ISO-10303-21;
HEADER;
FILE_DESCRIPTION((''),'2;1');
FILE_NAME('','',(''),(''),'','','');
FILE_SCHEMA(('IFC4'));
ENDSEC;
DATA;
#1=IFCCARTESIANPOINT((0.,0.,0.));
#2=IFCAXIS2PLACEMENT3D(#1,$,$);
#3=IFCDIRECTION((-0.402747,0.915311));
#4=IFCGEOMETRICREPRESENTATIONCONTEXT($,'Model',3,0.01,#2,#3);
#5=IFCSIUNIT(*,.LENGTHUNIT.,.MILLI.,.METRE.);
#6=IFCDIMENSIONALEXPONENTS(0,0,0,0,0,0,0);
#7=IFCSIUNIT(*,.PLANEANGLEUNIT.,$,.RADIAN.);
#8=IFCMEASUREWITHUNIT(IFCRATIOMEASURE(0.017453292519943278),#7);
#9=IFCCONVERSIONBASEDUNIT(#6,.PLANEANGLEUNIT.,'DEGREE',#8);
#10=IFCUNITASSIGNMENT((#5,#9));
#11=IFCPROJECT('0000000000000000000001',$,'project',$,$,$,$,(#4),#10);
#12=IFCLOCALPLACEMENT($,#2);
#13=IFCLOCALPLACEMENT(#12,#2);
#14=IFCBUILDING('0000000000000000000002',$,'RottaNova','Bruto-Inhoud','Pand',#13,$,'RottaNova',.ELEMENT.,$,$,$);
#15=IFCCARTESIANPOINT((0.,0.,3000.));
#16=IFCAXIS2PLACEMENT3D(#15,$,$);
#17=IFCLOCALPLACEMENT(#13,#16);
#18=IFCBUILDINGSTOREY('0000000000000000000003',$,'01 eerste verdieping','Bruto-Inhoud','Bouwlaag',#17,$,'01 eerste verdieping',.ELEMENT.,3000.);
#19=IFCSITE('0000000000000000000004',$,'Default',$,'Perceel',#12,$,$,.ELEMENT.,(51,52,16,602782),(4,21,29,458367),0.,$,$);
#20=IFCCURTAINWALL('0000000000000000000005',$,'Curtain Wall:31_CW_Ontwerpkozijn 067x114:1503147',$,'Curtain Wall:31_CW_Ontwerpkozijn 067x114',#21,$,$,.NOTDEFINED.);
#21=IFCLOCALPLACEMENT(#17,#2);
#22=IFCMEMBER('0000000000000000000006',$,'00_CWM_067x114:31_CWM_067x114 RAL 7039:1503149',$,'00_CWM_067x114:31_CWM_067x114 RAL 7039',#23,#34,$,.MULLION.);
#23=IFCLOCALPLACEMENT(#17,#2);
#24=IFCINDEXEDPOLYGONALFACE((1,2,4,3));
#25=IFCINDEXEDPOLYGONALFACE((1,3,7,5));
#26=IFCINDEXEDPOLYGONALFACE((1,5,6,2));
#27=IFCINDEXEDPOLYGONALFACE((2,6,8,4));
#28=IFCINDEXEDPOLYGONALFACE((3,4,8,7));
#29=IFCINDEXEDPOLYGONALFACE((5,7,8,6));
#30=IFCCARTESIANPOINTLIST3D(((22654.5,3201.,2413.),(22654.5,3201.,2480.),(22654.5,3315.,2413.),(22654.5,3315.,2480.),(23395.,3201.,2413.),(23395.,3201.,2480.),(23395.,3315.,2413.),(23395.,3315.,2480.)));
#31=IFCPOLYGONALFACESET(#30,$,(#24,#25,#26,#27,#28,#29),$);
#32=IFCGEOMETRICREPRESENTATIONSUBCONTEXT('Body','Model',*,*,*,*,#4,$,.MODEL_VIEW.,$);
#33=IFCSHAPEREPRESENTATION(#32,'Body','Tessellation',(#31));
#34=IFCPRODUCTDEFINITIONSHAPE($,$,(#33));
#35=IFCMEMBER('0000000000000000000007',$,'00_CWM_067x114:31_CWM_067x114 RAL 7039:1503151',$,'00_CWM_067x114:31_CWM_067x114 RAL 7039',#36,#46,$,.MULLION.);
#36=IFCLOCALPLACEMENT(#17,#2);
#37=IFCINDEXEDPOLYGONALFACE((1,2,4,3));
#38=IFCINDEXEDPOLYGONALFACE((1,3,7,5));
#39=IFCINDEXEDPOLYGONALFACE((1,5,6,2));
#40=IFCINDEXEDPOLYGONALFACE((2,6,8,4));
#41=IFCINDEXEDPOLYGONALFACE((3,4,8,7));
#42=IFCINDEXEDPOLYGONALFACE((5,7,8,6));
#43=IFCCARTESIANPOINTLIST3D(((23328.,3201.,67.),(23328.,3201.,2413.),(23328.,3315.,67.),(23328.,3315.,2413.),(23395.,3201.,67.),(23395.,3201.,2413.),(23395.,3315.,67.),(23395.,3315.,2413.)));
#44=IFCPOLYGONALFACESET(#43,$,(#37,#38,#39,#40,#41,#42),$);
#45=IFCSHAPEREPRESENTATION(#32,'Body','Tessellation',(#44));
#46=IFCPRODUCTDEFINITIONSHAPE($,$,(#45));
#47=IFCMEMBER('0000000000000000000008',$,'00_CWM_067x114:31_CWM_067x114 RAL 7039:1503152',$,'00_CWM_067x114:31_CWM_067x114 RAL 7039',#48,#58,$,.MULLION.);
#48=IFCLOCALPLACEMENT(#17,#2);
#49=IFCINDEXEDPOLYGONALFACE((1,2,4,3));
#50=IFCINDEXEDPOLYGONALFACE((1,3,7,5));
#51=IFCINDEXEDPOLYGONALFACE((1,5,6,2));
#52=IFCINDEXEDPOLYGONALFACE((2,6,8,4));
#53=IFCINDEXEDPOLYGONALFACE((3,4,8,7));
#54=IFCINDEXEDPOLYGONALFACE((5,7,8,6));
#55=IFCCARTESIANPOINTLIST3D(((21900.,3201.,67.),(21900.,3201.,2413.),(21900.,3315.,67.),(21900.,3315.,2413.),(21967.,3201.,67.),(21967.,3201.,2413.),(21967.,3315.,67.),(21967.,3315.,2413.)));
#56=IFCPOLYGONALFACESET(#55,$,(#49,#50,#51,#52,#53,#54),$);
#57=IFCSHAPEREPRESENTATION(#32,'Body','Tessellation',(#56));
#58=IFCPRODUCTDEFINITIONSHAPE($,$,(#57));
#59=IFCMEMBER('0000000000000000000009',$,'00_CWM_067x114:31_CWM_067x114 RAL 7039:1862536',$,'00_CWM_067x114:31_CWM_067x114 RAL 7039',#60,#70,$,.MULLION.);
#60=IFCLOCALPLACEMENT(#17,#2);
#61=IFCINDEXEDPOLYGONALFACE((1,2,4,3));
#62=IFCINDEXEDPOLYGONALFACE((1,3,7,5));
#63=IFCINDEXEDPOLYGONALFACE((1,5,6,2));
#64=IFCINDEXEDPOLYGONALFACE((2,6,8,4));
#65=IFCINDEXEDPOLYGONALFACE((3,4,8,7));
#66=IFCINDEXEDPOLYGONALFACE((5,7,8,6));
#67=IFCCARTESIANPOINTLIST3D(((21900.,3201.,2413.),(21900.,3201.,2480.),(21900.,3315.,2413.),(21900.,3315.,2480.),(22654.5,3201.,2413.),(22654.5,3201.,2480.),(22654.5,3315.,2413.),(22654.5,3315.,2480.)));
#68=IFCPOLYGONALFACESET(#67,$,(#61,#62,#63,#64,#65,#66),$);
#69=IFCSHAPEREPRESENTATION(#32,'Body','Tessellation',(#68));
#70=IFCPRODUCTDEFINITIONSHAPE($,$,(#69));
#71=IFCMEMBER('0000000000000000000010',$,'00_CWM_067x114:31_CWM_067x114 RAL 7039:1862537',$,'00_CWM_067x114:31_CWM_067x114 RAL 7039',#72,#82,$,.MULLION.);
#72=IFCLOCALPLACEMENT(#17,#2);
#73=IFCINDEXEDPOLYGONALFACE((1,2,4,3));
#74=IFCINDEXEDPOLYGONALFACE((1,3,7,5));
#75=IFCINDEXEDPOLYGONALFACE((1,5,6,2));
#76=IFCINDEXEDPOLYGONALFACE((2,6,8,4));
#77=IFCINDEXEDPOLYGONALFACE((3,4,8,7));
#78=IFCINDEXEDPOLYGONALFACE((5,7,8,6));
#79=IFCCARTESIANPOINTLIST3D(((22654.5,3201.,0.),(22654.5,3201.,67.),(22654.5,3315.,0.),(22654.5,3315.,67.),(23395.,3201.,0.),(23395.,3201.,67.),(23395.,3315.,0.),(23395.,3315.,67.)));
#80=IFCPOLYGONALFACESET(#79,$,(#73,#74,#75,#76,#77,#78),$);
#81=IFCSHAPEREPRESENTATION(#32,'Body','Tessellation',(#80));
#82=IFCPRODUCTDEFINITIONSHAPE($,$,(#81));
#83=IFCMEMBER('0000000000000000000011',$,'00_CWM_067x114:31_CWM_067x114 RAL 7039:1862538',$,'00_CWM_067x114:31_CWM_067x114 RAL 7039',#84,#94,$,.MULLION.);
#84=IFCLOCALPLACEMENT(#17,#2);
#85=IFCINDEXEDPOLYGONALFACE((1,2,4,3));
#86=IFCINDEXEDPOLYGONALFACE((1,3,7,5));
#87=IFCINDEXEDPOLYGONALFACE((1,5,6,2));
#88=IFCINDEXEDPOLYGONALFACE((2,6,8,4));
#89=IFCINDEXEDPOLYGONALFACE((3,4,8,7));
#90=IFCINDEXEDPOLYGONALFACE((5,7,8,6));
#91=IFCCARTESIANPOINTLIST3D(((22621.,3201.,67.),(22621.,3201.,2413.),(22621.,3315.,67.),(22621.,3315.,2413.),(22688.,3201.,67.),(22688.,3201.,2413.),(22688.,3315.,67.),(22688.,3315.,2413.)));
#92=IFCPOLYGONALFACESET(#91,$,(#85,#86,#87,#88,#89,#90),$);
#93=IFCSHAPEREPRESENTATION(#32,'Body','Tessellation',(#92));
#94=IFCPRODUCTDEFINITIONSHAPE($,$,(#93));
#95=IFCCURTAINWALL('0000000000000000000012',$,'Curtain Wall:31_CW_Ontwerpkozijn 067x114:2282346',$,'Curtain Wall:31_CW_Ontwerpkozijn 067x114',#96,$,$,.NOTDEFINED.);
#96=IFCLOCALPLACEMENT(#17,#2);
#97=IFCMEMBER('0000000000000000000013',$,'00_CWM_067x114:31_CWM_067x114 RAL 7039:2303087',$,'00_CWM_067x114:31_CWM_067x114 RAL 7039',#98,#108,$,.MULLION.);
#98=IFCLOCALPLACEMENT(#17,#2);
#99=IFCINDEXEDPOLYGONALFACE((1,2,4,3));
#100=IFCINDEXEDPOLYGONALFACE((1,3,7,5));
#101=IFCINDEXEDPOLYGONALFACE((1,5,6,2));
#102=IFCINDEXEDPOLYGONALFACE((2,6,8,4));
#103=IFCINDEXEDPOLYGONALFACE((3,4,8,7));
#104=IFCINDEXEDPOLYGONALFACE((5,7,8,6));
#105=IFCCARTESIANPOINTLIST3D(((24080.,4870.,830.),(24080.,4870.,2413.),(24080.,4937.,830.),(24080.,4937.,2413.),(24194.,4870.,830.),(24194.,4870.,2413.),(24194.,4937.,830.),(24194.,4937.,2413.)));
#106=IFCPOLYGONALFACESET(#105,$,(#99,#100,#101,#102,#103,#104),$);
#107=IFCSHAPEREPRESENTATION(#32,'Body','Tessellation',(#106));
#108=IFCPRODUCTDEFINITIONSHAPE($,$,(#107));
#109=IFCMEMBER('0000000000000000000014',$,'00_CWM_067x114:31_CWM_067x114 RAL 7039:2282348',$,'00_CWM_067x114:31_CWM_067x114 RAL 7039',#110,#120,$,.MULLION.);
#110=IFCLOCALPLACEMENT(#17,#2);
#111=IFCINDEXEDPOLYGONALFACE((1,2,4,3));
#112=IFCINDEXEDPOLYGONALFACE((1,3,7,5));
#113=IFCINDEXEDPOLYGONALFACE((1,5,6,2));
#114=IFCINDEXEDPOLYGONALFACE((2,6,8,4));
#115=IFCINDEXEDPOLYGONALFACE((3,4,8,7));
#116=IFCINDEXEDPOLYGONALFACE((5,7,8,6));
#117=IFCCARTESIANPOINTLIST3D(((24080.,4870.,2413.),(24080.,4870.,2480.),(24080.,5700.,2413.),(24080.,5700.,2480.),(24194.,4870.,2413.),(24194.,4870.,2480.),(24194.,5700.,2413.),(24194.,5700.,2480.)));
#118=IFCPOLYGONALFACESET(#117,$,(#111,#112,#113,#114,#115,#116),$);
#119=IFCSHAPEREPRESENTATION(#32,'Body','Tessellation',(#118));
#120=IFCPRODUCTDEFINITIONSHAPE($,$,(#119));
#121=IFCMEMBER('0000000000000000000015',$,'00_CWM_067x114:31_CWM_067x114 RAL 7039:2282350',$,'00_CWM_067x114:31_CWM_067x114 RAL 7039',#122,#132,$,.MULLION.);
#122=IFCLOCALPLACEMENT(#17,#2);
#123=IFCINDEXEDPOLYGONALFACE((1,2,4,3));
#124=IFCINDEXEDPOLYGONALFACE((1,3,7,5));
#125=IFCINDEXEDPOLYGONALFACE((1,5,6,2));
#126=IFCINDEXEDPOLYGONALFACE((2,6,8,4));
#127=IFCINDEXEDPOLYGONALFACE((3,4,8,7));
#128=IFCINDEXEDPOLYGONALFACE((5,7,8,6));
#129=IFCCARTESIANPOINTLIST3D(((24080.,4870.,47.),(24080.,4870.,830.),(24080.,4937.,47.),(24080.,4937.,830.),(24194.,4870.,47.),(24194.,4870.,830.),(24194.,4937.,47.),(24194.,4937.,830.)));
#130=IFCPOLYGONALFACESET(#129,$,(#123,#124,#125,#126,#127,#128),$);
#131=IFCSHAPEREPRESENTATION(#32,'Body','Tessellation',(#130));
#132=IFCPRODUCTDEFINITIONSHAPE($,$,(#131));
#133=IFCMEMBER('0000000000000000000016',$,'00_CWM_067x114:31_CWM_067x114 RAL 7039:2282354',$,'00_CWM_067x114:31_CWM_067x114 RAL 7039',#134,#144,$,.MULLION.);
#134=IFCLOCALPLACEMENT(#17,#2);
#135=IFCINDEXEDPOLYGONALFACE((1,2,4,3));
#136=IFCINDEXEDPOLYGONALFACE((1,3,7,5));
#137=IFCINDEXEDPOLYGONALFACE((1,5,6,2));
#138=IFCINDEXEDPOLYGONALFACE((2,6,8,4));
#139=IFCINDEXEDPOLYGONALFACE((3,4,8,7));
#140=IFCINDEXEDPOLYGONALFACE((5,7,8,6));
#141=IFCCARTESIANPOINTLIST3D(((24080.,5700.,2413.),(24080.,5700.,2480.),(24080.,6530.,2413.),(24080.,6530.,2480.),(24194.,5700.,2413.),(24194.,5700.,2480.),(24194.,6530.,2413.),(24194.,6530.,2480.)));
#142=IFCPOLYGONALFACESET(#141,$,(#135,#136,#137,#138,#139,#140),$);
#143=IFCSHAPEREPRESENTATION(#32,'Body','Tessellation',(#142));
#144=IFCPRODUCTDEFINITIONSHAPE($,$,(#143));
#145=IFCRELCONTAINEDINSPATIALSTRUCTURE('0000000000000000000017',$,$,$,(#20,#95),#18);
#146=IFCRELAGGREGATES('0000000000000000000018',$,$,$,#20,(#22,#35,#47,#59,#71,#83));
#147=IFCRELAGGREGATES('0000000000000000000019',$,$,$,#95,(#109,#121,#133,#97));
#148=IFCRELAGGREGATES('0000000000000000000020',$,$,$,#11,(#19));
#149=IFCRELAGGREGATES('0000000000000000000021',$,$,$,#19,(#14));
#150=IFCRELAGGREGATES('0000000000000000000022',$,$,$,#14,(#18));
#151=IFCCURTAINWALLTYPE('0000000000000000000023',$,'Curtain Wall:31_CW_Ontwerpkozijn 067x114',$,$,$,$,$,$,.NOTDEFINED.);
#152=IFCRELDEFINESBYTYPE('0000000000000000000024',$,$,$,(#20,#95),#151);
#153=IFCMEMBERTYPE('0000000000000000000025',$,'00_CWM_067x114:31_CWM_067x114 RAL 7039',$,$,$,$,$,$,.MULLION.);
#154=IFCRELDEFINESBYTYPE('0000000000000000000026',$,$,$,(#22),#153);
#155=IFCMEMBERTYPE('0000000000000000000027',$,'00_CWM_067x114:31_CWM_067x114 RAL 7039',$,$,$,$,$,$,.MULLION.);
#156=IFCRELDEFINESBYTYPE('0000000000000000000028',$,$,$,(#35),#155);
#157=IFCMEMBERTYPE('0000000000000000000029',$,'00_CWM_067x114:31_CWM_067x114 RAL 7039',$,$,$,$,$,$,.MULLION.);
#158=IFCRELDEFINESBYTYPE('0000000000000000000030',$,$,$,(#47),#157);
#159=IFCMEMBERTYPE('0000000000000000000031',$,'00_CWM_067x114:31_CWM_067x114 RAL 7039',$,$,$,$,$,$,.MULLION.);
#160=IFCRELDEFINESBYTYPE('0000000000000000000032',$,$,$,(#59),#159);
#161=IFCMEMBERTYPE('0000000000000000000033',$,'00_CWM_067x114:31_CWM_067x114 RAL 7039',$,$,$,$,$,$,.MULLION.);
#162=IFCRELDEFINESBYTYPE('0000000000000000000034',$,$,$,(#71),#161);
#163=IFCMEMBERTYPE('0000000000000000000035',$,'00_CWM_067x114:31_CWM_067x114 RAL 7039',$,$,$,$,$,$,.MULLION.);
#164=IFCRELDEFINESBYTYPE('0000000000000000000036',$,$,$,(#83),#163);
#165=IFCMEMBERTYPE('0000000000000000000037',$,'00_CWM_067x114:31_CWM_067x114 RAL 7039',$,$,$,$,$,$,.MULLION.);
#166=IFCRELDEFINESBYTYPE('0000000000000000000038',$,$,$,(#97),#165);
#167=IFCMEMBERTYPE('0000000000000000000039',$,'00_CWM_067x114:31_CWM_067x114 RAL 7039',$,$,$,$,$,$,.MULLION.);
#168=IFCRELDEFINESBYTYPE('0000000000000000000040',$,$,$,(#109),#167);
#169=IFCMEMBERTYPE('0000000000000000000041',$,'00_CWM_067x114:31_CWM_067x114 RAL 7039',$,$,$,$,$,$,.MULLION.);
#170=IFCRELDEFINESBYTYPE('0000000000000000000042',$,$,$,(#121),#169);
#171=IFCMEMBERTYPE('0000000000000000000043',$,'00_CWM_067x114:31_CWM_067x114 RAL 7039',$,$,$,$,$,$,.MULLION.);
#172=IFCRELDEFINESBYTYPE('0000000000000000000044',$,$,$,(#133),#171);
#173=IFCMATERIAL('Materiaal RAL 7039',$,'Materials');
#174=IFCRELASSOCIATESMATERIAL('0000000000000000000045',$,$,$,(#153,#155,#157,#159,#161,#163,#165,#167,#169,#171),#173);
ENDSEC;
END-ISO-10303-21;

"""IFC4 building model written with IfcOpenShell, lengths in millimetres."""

from ifc_helpers import new_model, entity, si_unit, converted_unit, direction, frame, frame_2d, origin, origin_2d_with_axis, place, context, subcontext, project, spatial, rectangle, extrude, source, transform, mapped, material, material_profile, profile_set, type_object, type_shapes, element, aggregate, save


model = new_model("IFC4")

# Units and contexts
model_context = context("Model", 3, precision=0.01, world=origin(), true_north=direction((-0.402747, 0.915311)))
body_context = subcontext(model_context, "Body", "Model", "MODEL_VIEW")
ifc_project = project(units=[si_unit("LENGTHUNIT", "METRE", prefix="MILLI"), converted_unit("PLANEANGLEUNIT", "DEGREE", entity("IfcRatioMeasure", 0.017453292519943278), si_unit("PLANEANGLEUNIT", "RADIAN"), dimensions=[0, 0, 0, 0, 0, 0, 0])], contexts=[model_context])

# Site, building, storey
site_placement = place(None, origin())
site = spatial("IfcSite", under=ifc_project, at=site_placement, Name="Default", ObjectType="Perceel", CompositionType="ELEMENT", RefLatitude=(51, 52, 16, 602782), RefLongitude=(4, 21, 29, 458367), RefElevation=0.0)
building_placement = place(site_placement, origin())
building = spatial("IfcBuilding", under=site, at=building_placement, Name="RottaNova", Description="Bruto-Inhoud", ObjectType="Pand", LongName="RottaNova", CompositionType="ELEMENT")
storey_placement = place(building_placement, frame((0.0, 0.0, 3000.0)))
storey = spatial("IfcBuildingStorey", under=building, at=storey_placement, Name="01 eerste verdieping", Description="Bruto-Inhoud", ObjectType="Bouwlaag", LongName="01 eerste verdieping", CompositionType="ELEMENT", Elevation=3000.0)

# Curtain walls, members
curtain_wall_type = type_object("IfcCurtainWallType", Name="Curtain Wall:31_CW_Ontwerpkozijn 067x114", PredefinedType="NOTDEFINED")
curtain_wall_1_placement = place(storey_placement, frame((0.0, 0.0, -3000.0)))
curtain_wall_1 = element("IfcCurtainWall", 1, at=curtain_wall_1_placement, inside=storey, type_object=curtain_wall_type, Name="Curtain Wall:31_CW_Ontwerpkozijn 067x114:1503147", ObjectType="Curtain Wall:31_CW_Ontwerpkozijn 067x114", PredefinedType="NOTDEFINED")
ifc_material_1 = material(Name="Materiaal RAL 7039", Category="Materials")
ifc_material_profile = material_profile(ifc_material_1, rectangle(XDim=114.0, YDim=67.0, at=origin_2d_with_axis()), Name="31_CWM_067x114 RAL 7039")
ifc_profile_set = profile_set([ifc_material_profile], Name="31_CWM_067x114 RAL 7039")
member_type_1 = type_object("IfcMemberType", Name="00_CWM_067x114:31_CWM_067x114 RAL 7039", PredefinedType="MULLION", material=ifc_profile_set)
shared_shape_1 = source(origin(), body_context, "Body", "SweptSolid", [
    extrude(rectangle(XDim=114.0, YDim=67.0, at=origin_2d_with_axis()), frame((-33.5, 57.0, -740.5), z_axis=(0.0, 0.0, 1.0), x_axis=(0.0, -1.0, 0.0)), (0.0, 0.0, 1.0), 740.5),
])
type_shapes(member_type_1, [shared_shape_1])
member_1_placement = place(curtain_wall_1_placement, frame((23395.0, 3315.0, 5480.0), z_axis=(1.0, 0.0, 0.0), x_axis=(0.0, 0.0, 1.0)))
member_1 = element("IfcMember", 2, at=member_1_placement, type_object=member_type_1, Name="00_CWM_067x114:31_CWM_067x114 RAL 7039:1503149", ObjectType="00_CWM_067x114:31_CWM_067x114 RAL 7039", PredefinedType="MULLION", context=body_context, shape_type="MappedRepresentation", body=[
    mapped(shared_shape_1, transform((0.0, 0.0, 0.0), scale=1.0)),
])
member_type_2 = type_object("IfcMemberType", Name="00_CWM_067x114:31_CWM_067x114 RAL 7039", PredefinedType="MULLION", material=ifc_profile_set)
shared_shape_2 = source(origin(), body_context, "Body", "SweptSolid", [
    extrude(rectangle(XDim=114.0, YDim=67.0, at=origin_2d_with_axis()), frame((-33.5, 57.0, -2346.0), z_axis=(0.0, 0.0, 1.0), x_axis=(0.0, -1.0, 0.0)), (0.0, 0.0, 1.0), 2346.0),
])
type_shapes(member_type_2, [shared_shape_2])
member_2_placement = place(curtain_wall_1_placement, frame((23395.0, 3315.0, 3067.0), z_axis=(0.0, 0.0, -1.0), x_axis=(1.0, 0.0, 0.0)))
member_2 = element("IfcMember", 3, at=member_2_placement, type_object=member_type_2, Name="00_CWM_067x114:31_CWM_067x114 RAL 7039:1503151", ObjectType="00_CWM_067x114:31_CWM_067x114 RAL 7039", PredefinedType="MULLION", context=body_context, shape_type="MappedRepresentation", body=[
    mapped(shared_shape_2, transform((0.0, 0.0, 0.0), scale=1.0)),
])
member_type_3 = type_object("IfcMemberType", Name="00_CWM_067x114:31_CWM_067x114 RAL 7039", PredefinedType="MULLION", material=ifc_profile_set)
shared_shape_3 = source(origin(), body_context, "Body", "SweptSolid", [
    extrude(rectangle(XDim=114.0, YDim=67.0, at=origin_2d_with_axis()), frame((-33.5, 57.0, -2346.0), z_axis=(0.0, 0.0, 1.0), x_axis=(0.0, -1.0, 0.0)), (0.0, 0.0, 1.0), 2346.0),
])
type_shapes(member_type_3, [shared_shape_3])
member_3_placement = place(curtain_wall_1_placement, frame((21900.0, 3315.0, 5413.0), z_axis=(0.0, 0.0, 1.0), x_axis=(-1.0, 0.0, 0.0)))
member_3 = element("IfcMember", 4, at=member_3_placement, type_object=member_type_3, Name="00_CWM_067x114:31_CWM_067x114 RAL 7039:1503152", ObjectType="00_CWM_067x114:31_CWM_067x114 RAL 7039", PredefinedType="MULLION", context=body_context, shape_type="MappedRepresentation", body=[
    mapped(shared_shape_3, transform((0.0, 0.0, 0.0), scale=1.0)),
])
member_type_4 = type_object("IfcMemberType", Name="00_CWM_067x114:31_CWM_067x114 RAL 7039", PredefinedType="MULLION", material=ifc_profile_set)
shared_shape_4 = source(origin(), body_context, "Body", "SweptSolid", [
    extrude(rectangle(XDim=114.0, YDim=67.0, at=origin_2d_with_axis()), frame((-33.5, 57.0, -754.5), z_axis=(0.0, 0.0, 1.0), x_axis=(0.0, -1.0, 0.0)), (0.0, 0.0, 1.0), 754.5),
])
type_shapes(member_type_4, [shared_shape_4])
member_4_placement = place(curtain_wall_1_placement, frame((22654.5, 3315.0, 5480.0), z_axis=(1.0, 0.0, 0.0), x_axis=(0.0, 0.0, 1.0)))
member_4 = element("IfcMember", 5, at=member_4_placement, type_object=member_type_4, Name="00_CWM_067x114:31_CWM_067x114 RAL 7039:1862536", ObjectType="00_CWM_067x114:31_CWM_067x114 RAL 7039", PredefinedType="MULLION", context=body_context, shape_type="MappedRepresentation", body=[
    mapped(shared_shape_4, transform((0.0, 0.0, 0.0), scale=1.0)),
])
member_type_5 = type_object("IfcMemberType", Name="00_CWM_067x114:31_CWM_067x114 RAL 7039", PredefinedType="MULLION", material=ifc_profile_set)
shared_shape_5 = source(origin(), body_context, "Body", "SweptSolid", [
    extrude(rectangle(XDim=114.0, YDim=67.0, at=origin_2d_with_axis()), frame((-33.5, 57.0, -740.5), z_axis=(0.0, 0.0, 1.0), x_axis=(0.0, -1.0, 0.0)), (0.0, 0.0, 1.0), 740.5),
])
type_shapes(member_type_5, [shared_shape_5])
member_5_placement = place(curtain_wall_1_placement, frame((22654.5, 3315.0, 3000.0), z_axis=(-1.0, 0.0, 0.0), x_axis=(0.0, 0.0, -1.0)))
member_5 = element("IfcMember", 6, at=member_5_placement, type_object=member_type_5, Name="00_CWM_067x114:31_CWM_067x114 RAL 7039:1862537", ObjectType="00_CWM_067x114:31_CWM_067x114 RAL 7039", PredefinedType="MULLION", context=body_context, shape_type="MappedRepresentation", body=[
    mapped(shared_shape_5, transform((0.0, 0.0, 0.0), scale=1.0)),
])
member_type_6 = type_object("IfcMemberType", Name="00_CWM_067x114:31_CWM_067x114 RAL 7039", PredefinedType="MULLION", material=ifc_profile_set)
shared_shape_6 = source(origin(), body_context, "Body", "SweptSolid", [
    extrude(rectangle(XDim=114.0, YDim=67.0, at=origin_2d_with_axis()), frame((0.0, 57.0, -2346.0), z_axis=(0.0, 0.0, 1.0), x_axis=(0.0, -1.0, 0.0)), (0.0, 0.0, 1.0), 2346.0),
])
type_shapes(member_type_6, [shared_shape_6])
member_6_placement = place(curtain_wall_1_placement, frame((22654.5, 3315.0, 3067.0), z_axis=(0.0, 0.0, -1.0), x_axis=(1.0, 0.0, 0.0)))
member_6 = element("IfcMember", 7, at=member_6_placement, type_object=member_type_6, Name="00_CWM_067x114:31_CWM_067x114 RAL 7039:1862538", ObjectType="00_CWM_067x114:31_CWM_067x114 RAL 7039", PredefinedType="MULLION", context=body_context, shape_type="MappedRepresentation", body=[
    mapped(shared_shape_6, transform((0.0, 0.0, 0.0), scale=1.0)),
])
aggregate(curtain_wall_1, [member_1, member_2, member_3, member_4, member_5, member_6])
curtain_wall_2_placement = place(storey_placement, frame((0.0, 0.0, -3000.0)))
curtain_wall_2 = element("IfcCurtainWall", 8, at=curtain_wall_2_placement, inside=storey, type_object=curtain_wall_type, Name="Curtain Wall:31_CW_Ontwerpkozijn 067x114:2282346", ObjectType="Curtain Wall:31_CW_Ontwerpkozijn 067x114", PredefinedType="NOTDEFINED")
member_type_7 = type_object("IfcMemberType", Name="00_CWM_067x114:31_CWM_067x114 RAL 7039", PredefinedType="MULLION", material=ifc_profile_set)
shared_shape_7 = source(origin(), body_context, "Body", "SweptSolid", [
    extrude(rectangle(XDim=114.0, YDim=67.0, at=frame_2d((0.0, 0.0), x_axis=(1.0, 0.0))), frame((-33.5, -57.0, -1583.0), z_axis=(0.0, 0.0, 1.0), x_axis=(0.0, -1.0, 0.0)), (0.0, 0.0, 1.0), 1583.0),
])
type_shapes(member_type_7, [shared_shape_7])
member_7_placement = place(curtain_wall_2_placement, frame((24080.0, 4870.0, 3830.0), z_axis=(0.0, 0.0, -1.0), x_axis=(0.0, -1.0, 0.0)))
member_7 = element("IfcMember", 9, at=member_7_placement, type_object=member_type_7, Name="00_CWM_067x114:31_CWM_067x114 RAL 7039:2303087", ObjectType="00_CWM_067x114:31_CWM_067x114 RAL 7039", PredefinedType="MULLION", context=body_context, shape_type="MappedRepresentation", body=[
    mapped(shared_shape_7, transform((0.0, 0.0, 0.0), scale=1.0)),
])
member_type_8 = type_object("IfcMemberType", Name="00_CWM_067x114:31_CWM_067x114 RAL 7039", PredefinedType="MULLION", material=ifc_profile_set)
shared_shape_8 = source(origin(), body_context, "Body", "SweptSolid", [
    extrude(rectangle(XDim=114.0, YDim=67.0, at=frame_2d((0.0, 0.0), x_axis=(1.0, 0.0))), frame((-33.5, -57.0, -830.0), z_axis=(0.0, 0.0, 1.0), x_axis=(0.0, -1.0, 0.0)), (0.0, 0.0, 1.0), 830.0),
])
type_shapes(member_type_8, [shared_shape_8])
member_8_placement = place(curtain_wall_2_placement, frame((24080.0, 4870.0, 5480.0), z_axis=(0.0, -1.0, 0.0), x_axis=(0.0, 0.0, 1.0)))
member_8 = element("IfcMember", 10, at=member_8_placement, type_object=member_type_8, Name="00_CWM_067x114:31_CWM_067x114 RAL 7039:2282348", ObjectType="00_CWM_067x114:31_CWM_067x114 RAL 7039", PredefinedType="MULLION", context=body_context, shape_type="MappedRepresentation", body=[
    mapped(shared_shape_8, transform((0.0, 0.0, 0.0), scale=1.0)),
])
member_type_9 = type_object("IfcMemberType", Name="00_CWM_067x114:31_CWM_067x114 RAL 7039", PredefinedType="MULLION", material=ifc_profile_set)
shared_shape_9 = source(origin(), body_context, "Body", "SweptSolid", [
    extrude(rectangle(XDim=114.0, YDim=67.0, at=frame_2d((0.0, 0.0), x_axis=(1.0, 0.0))), frame((-33.5, -57.0, -783.0), z_axis=(0.0, 0.0, 1.0), x_axis=(0.0, -1.0, 0.0)), (0.0, 0.0, 1.0), 783.0),
])
type_shapes(member_type_9, [shared_shape_9])
member_9_placement = place(curtain_wall_2_placement, frame((24080.0, 4870.0, 3047.0), z_axis=(0.0, 0.0, -1.0), x_axis=(0.0, -1.0, 0.0)))
member_9 = element("IfcMember", 11, at=member_9_placement, type_object=member_type_9, Name="00_CWM_067x114:31_CWM_067x114 RAL 7039:2282350", ObjectType="00_CWM_067x114:31_CWM_067x114 RAL 7039", PredefinedType="MULLION", context=body_context, shape_type="MappedRepresentation", body=[
    mapped(shared_shape_9, transform((0.0, 0.0, 0.0), scale=1.0)),
])
member_type_10 = type_object("IfcMemberType", Name="00_CWM_067x114:31_CWM_067x114 RAL 7039", PredefinedType="MULLION", material=ifc_profile_set)
shared_shape_10 = source(origin(), body_context, "Body", "SweptSolid", [
    extrude(rectangle(XDim=114.0, YDim=67.0, at=frame_2d((0.0, 0.0), x_axis=(1.0, 0.0))), frame((-33.5, -57.0, -830.0), z_axis=(0.0, 0.0, 1.0), x_axis=(0.0, -1.0, 0.0)), (0.0, 0.0, 1.0), 830.0),
])
type_shapes(member_type_10, [shared_shape_10])
member_10_placement = place(curtain_wall_2_placement, frame((24080.0, 5700.0, 5480.0), z_axis=(0.0, -1.0, 0.0), x_axis=(0.0, 0.0, 1.0)))
member_10 = element("IfcMember", 12, at=member_10_placement, type_object=member_type_10, Name="00_CWM_067x114:31_CWM_067x114 RAL 7039:2282354", ObjectType="00_CWM_067x114:31_CWM_067x114 RAL 7039", PredefinedType="MULLION", context=body_context, shape_type="MappedRepresentation", body=[
    mapped(shared_shape_10, transform((0.0, 0.0, 0.0), scale=1.0)),
])

aggregate(curtain_wall_2, [member_8, member_9, member_10, member_7])

save(model, "model.ifc")
